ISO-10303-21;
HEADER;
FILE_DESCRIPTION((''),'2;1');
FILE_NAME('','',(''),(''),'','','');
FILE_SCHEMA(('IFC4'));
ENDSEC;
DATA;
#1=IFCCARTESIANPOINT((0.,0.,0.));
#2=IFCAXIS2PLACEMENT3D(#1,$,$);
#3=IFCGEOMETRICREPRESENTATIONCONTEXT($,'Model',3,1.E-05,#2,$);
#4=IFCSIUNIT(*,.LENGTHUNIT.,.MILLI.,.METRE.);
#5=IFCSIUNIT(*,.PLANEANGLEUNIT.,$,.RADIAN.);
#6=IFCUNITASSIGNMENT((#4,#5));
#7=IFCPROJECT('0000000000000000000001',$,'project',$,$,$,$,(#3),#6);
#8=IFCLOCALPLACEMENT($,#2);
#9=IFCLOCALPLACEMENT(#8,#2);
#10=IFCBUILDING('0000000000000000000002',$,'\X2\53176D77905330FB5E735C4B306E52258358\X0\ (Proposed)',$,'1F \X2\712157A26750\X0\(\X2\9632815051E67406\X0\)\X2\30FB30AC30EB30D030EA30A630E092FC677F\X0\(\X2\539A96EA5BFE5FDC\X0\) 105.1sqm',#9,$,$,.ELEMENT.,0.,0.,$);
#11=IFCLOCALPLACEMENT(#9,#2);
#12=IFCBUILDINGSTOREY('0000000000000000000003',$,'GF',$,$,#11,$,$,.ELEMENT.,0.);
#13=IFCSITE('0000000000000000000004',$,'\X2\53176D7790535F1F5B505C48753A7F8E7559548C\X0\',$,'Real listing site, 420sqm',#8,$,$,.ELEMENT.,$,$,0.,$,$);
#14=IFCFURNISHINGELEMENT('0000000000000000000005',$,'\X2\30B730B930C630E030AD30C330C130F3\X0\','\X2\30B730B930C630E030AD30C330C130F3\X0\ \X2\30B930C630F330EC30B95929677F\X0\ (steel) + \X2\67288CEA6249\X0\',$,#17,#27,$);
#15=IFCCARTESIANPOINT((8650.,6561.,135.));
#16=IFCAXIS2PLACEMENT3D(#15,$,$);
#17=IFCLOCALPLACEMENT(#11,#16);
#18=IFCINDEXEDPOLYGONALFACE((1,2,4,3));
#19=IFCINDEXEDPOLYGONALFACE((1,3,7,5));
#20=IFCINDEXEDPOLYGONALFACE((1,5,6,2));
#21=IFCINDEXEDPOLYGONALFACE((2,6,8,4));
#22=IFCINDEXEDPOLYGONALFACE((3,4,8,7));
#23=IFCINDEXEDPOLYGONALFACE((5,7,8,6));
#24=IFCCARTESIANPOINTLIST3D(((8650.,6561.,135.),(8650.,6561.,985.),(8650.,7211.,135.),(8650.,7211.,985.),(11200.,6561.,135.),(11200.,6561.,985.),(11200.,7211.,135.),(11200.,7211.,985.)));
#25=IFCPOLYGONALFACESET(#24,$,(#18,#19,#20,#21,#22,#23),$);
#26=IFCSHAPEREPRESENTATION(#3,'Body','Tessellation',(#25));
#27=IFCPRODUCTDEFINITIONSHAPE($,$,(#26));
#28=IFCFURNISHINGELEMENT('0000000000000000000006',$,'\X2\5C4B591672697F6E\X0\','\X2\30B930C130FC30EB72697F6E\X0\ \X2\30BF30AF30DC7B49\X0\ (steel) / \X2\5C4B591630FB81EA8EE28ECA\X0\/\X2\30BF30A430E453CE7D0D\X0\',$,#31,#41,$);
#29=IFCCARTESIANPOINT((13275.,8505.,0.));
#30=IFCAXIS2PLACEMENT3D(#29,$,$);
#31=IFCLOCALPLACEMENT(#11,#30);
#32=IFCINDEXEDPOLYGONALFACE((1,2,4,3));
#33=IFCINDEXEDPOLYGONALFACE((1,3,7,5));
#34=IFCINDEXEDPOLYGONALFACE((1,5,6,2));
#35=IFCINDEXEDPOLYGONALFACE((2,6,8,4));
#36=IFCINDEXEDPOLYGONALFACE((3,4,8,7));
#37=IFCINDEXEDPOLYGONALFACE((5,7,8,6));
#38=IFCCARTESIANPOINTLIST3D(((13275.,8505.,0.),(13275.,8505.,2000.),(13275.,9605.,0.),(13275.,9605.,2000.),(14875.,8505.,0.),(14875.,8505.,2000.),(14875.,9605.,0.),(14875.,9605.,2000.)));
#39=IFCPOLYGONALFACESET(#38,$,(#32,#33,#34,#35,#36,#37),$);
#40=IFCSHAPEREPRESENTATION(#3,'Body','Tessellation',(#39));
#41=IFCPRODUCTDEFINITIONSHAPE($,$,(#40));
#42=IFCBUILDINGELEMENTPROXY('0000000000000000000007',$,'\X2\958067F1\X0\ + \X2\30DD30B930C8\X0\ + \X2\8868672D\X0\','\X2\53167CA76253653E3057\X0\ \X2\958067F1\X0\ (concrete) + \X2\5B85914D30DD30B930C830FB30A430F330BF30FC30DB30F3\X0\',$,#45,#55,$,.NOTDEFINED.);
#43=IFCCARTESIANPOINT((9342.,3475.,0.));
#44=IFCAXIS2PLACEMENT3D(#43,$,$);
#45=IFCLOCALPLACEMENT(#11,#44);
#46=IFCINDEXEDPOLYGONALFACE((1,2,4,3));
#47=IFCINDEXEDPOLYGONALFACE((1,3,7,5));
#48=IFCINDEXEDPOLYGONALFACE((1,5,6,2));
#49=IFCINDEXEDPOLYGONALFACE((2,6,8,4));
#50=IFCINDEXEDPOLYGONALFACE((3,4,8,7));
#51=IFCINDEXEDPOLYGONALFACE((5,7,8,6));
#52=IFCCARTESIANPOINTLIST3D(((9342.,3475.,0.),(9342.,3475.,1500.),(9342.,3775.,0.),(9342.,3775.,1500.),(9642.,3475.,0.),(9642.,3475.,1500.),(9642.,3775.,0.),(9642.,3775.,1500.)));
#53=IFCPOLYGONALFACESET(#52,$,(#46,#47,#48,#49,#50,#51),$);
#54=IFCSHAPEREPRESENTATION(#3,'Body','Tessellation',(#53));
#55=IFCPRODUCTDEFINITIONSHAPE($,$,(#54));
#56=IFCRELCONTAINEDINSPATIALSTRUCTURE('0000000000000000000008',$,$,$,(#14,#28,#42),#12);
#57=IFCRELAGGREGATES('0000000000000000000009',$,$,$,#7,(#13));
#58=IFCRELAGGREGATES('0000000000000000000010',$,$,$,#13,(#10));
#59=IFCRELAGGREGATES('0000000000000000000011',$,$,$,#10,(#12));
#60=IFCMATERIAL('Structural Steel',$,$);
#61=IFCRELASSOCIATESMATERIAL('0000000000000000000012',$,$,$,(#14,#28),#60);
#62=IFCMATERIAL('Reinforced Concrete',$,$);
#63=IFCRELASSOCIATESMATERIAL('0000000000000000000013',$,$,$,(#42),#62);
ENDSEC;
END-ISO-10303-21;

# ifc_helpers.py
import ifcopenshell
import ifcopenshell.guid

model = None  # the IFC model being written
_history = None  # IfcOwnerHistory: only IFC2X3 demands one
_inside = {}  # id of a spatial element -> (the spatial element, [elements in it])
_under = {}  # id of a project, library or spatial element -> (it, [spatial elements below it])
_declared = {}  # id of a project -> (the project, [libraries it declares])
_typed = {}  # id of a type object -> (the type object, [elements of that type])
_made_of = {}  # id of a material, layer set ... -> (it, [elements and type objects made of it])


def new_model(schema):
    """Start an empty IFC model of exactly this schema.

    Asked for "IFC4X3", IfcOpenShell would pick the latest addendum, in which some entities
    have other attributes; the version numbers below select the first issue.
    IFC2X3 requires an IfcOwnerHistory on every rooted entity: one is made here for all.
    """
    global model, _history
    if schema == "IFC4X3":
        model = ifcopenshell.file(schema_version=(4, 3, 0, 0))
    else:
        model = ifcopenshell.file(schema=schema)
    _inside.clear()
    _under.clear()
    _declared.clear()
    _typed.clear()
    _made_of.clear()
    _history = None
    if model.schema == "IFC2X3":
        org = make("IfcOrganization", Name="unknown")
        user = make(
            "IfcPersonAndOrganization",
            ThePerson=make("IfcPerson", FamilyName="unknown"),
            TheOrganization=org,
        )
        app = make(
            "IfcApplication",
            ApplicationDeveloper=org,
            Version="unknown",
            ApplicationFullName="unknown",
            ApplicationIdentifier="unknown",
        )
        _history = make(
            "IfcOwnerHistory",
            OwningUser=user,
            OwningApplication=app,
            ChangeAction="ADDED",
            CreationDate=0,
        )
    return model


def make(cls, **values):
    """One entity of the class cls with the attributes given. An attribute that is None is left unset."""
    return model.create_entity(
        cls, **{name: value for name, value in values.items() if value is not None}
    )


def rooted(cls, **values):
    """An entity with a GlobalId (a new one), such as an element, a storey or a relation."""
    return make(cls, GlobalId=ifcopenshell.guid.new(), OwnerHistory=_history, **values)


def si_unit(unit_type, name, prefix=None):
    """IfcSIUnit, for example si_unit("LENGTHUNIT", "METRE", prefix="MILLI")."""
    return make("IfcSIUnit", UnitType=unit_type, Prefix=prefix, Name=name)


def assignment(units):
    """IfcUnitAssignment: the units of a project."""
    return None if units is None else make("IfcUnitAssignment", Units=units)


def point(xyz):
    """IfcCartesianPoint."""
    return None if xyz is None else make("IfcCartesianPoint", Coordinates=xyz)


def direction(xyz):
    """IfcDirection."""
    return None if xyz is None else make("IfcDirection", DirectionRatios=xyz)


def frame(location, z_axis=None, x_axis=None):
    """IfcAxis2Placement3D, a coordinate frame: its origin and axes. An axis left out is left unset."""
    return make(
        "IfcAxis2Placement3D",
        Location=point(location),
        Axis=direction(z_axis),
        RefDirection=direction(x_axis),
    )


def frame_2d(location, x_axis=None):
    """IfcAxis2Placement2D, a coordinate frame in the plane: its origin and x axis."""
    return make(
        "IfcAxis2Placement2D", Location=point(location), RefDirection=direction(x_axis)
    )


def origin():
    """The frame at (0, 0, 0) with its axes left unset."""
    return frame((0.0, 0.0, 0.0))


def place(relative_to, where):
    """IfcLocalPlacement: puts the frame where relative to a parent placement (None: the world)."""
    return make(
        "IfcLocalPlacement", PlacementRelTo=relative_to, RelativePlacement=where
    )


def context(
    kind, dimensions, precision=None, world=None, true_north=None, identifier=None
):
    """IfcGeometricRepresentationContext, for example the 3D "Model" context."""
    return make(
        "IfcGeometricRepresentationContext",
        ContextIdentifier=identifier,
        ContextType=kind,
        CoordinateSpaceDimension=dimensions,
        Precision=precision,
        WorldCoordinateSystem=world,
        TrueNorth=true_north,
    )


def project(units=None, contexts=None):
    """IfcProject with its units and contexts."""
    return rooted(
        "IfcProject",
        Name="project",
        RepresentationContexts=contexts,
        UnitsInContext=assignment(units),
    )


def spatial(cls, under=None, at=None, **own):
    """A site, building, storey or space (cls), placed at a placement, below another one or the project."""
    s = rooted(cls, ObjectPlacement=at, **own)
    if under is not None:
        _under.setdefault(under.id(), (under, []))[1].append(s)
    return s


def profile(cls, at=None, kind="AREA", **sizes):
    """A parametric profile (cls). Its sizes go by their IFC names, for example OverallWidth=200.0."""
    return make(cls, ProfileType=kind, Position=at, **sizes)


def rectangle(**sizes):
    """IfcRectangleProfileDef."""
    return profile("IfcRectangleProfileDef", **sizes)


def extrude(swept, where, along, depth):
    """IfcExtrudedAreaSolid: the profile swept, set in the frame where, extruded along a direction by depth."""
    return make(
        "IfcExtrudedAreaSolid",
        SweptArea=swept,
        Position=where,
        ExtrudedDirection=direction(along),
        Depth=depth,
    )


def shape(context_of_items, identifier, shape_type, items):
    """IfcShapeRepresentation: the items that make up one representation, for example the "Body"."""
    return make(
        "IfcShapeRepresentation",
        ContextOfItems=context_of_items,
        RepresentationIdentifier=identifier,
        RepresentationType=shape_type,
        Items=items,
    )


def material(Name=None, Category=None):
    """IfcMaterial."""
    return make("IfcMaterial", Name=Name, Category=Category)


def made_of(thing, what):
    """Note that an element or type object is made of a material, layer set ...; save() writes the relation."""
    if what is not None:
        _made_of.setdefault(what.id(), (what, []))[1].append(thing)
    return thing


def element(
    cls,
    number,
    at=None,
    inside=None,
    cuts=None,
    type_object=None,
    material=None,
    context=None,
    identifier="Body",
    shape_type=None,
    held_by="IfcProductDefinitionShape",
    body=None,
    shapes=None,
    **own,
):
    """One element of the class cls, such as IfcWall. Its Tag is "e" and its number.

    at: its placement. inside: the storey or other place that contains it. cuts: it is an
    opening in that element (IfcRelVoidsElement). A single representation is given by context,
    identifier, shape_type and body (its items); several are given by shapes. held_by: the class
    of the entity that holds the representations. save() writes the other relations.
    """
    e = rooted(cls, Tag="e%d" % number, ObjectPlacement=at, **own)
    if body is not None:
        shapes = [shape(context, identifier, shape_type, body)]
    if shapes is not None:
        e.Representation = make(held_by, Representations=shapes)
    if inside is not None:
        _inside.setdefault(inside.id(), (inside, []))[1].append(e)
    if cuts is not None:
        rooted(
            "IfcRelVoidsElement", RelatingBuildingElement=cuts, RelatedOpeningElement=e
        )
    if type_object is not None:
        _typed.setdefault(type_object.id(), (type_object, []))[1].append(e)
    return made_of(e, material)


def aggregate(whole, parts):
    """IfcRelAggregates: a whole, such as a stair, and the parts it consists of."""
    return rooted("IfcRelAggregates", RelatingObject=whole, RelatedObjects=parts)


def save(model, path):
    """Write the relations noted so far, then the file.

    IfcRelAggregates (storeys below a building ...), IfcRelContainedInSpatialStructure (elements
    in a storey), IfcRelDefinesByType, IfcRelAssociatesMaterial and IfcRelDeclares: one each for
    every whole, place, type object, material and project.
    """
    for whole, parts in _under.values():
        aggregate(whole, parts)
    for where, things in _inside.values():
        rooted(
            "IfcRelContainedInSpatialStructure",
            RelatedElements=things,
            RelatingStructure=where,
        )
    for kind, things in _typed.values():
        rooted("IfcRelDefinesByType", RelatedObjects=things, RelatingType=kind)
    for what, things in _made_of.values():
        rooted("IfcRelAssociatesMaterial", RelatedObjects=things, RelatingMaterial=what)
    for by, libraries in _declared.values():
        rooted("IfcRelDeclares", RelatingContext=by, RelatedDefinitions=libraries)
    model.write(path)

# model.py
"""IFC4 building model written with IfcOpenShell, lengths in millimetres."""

from ifc_helpers import new_model, si_unit, frame, frame_2d, origin, place, context, project, spatial, rectangle, extrude, material, element, save


model = new_model("IFC4")

# Units and contexts
model_context = context("Model", 3, precision=1e-05, world=origin())
ifc_project = project(units=[si_unit("LENGTHUNIT", "METRE", prefix="MILLI"), si_unit("PLANEANGLEUNIT", "RADIAN")], contexts=[model_context])

# Site, building, storey
site_placement = place(None, origin())
site = spatial("IfcSite", under=ifc_project, at=site_placement, Name="北海道弟子屈町美留和", ObjectType="Real listing site, 420sqm", CompositionType="ELEMENT", RefElevation=0.0)
building_placement = place(site_placement, origin())
building = spatial("IfcBuilding", under=site, at=building_placement, Name="北海道・平屋の別荘 (Proposed)", ObjectType="1F 無垢材(防腐処理)・ガルバリウム鋼板(厚雪対応) 105.1sqm", CompositionType="ELEMENT", ElevationOfRefHeight=0.0, ElevationOfTerrain=0.0)
storey_placement = place(building_placement, origin())
storey = spatial("IfcBuildingStorey", under=building, at=storey_placement, Name="GF", CompositionType="ELEMENT", Elevation=0.0)

# Shared definitions
ifc_material_1 = material(Name="Structural Steel")

# Shared definitions
ifc_material_2 = material(Name="Reinforced Concrete")

# Furnishing elements
furnishing_1_placement = place(storey_placement, frame((8650.0, 6561.0, 135.0)))
element("IfcFurnishingElement", 1, at=furnishing_1_placement, inside=storey, material=ifc_material_1, Name="システムキッチン", Description="システムキッチン ステンレス天板 (steel) + 木質扉", context=model_context, shape_type="SweptSolid", body=[
    extrude(rectangle(XDim=2550.0, YDim=650.0, at=frame_2d((1275.0, 325.0))), frame((8650.0, 6561.0, 135.0)), (0.0, 0.0, 1.0), 850.0),
])
furnishing_2_placement = place(storey_placement, frame((13275.0, 8505.0, 0.0)))
element("IfcFurnishingElement", 2, at=furnishing_2_placement, inside=storey, material=ifc_material_1, Name="屋外物置", Description="スチール物置 タクボ等 (steel) / 屋外・自転車/タイヤ収納", context=model_context, shape_type="SweptSolid", body=[
    extrude(rectangle(XDim=1600.0, YDim=1100.0, at=frame_2d((800.0, 550.0))), frame((13275.0, 8505.0, 0.0)), (0.0, 0.0, 1.0), 2000.0),
])

# Building element proxy
proxy_placement = place(storey_placement, frame((9342.0, 3475.0, 0.0)))
element("IfcBuildingElementProxy", 3, at=proxy_placement, inside=storey, material=ifc_material_2, Name="門柱 + ポスト + 表札", Description="化粧打放し 門柱 (concrete) + 宅配ポスト・インターホン", PredefinedType="NOTDEFINED", context=model_context, shape_type="SweptSolid", body=[
    extrude(rectangle(XDim=300.0, YDim=300.0, at=frame_2d((150.0, 150.0))), frame((9342.0, 3475.0, 0.0)), (0.0, 0.0, 1.0), 1500.0),
])

save(model, "model.ifc")
